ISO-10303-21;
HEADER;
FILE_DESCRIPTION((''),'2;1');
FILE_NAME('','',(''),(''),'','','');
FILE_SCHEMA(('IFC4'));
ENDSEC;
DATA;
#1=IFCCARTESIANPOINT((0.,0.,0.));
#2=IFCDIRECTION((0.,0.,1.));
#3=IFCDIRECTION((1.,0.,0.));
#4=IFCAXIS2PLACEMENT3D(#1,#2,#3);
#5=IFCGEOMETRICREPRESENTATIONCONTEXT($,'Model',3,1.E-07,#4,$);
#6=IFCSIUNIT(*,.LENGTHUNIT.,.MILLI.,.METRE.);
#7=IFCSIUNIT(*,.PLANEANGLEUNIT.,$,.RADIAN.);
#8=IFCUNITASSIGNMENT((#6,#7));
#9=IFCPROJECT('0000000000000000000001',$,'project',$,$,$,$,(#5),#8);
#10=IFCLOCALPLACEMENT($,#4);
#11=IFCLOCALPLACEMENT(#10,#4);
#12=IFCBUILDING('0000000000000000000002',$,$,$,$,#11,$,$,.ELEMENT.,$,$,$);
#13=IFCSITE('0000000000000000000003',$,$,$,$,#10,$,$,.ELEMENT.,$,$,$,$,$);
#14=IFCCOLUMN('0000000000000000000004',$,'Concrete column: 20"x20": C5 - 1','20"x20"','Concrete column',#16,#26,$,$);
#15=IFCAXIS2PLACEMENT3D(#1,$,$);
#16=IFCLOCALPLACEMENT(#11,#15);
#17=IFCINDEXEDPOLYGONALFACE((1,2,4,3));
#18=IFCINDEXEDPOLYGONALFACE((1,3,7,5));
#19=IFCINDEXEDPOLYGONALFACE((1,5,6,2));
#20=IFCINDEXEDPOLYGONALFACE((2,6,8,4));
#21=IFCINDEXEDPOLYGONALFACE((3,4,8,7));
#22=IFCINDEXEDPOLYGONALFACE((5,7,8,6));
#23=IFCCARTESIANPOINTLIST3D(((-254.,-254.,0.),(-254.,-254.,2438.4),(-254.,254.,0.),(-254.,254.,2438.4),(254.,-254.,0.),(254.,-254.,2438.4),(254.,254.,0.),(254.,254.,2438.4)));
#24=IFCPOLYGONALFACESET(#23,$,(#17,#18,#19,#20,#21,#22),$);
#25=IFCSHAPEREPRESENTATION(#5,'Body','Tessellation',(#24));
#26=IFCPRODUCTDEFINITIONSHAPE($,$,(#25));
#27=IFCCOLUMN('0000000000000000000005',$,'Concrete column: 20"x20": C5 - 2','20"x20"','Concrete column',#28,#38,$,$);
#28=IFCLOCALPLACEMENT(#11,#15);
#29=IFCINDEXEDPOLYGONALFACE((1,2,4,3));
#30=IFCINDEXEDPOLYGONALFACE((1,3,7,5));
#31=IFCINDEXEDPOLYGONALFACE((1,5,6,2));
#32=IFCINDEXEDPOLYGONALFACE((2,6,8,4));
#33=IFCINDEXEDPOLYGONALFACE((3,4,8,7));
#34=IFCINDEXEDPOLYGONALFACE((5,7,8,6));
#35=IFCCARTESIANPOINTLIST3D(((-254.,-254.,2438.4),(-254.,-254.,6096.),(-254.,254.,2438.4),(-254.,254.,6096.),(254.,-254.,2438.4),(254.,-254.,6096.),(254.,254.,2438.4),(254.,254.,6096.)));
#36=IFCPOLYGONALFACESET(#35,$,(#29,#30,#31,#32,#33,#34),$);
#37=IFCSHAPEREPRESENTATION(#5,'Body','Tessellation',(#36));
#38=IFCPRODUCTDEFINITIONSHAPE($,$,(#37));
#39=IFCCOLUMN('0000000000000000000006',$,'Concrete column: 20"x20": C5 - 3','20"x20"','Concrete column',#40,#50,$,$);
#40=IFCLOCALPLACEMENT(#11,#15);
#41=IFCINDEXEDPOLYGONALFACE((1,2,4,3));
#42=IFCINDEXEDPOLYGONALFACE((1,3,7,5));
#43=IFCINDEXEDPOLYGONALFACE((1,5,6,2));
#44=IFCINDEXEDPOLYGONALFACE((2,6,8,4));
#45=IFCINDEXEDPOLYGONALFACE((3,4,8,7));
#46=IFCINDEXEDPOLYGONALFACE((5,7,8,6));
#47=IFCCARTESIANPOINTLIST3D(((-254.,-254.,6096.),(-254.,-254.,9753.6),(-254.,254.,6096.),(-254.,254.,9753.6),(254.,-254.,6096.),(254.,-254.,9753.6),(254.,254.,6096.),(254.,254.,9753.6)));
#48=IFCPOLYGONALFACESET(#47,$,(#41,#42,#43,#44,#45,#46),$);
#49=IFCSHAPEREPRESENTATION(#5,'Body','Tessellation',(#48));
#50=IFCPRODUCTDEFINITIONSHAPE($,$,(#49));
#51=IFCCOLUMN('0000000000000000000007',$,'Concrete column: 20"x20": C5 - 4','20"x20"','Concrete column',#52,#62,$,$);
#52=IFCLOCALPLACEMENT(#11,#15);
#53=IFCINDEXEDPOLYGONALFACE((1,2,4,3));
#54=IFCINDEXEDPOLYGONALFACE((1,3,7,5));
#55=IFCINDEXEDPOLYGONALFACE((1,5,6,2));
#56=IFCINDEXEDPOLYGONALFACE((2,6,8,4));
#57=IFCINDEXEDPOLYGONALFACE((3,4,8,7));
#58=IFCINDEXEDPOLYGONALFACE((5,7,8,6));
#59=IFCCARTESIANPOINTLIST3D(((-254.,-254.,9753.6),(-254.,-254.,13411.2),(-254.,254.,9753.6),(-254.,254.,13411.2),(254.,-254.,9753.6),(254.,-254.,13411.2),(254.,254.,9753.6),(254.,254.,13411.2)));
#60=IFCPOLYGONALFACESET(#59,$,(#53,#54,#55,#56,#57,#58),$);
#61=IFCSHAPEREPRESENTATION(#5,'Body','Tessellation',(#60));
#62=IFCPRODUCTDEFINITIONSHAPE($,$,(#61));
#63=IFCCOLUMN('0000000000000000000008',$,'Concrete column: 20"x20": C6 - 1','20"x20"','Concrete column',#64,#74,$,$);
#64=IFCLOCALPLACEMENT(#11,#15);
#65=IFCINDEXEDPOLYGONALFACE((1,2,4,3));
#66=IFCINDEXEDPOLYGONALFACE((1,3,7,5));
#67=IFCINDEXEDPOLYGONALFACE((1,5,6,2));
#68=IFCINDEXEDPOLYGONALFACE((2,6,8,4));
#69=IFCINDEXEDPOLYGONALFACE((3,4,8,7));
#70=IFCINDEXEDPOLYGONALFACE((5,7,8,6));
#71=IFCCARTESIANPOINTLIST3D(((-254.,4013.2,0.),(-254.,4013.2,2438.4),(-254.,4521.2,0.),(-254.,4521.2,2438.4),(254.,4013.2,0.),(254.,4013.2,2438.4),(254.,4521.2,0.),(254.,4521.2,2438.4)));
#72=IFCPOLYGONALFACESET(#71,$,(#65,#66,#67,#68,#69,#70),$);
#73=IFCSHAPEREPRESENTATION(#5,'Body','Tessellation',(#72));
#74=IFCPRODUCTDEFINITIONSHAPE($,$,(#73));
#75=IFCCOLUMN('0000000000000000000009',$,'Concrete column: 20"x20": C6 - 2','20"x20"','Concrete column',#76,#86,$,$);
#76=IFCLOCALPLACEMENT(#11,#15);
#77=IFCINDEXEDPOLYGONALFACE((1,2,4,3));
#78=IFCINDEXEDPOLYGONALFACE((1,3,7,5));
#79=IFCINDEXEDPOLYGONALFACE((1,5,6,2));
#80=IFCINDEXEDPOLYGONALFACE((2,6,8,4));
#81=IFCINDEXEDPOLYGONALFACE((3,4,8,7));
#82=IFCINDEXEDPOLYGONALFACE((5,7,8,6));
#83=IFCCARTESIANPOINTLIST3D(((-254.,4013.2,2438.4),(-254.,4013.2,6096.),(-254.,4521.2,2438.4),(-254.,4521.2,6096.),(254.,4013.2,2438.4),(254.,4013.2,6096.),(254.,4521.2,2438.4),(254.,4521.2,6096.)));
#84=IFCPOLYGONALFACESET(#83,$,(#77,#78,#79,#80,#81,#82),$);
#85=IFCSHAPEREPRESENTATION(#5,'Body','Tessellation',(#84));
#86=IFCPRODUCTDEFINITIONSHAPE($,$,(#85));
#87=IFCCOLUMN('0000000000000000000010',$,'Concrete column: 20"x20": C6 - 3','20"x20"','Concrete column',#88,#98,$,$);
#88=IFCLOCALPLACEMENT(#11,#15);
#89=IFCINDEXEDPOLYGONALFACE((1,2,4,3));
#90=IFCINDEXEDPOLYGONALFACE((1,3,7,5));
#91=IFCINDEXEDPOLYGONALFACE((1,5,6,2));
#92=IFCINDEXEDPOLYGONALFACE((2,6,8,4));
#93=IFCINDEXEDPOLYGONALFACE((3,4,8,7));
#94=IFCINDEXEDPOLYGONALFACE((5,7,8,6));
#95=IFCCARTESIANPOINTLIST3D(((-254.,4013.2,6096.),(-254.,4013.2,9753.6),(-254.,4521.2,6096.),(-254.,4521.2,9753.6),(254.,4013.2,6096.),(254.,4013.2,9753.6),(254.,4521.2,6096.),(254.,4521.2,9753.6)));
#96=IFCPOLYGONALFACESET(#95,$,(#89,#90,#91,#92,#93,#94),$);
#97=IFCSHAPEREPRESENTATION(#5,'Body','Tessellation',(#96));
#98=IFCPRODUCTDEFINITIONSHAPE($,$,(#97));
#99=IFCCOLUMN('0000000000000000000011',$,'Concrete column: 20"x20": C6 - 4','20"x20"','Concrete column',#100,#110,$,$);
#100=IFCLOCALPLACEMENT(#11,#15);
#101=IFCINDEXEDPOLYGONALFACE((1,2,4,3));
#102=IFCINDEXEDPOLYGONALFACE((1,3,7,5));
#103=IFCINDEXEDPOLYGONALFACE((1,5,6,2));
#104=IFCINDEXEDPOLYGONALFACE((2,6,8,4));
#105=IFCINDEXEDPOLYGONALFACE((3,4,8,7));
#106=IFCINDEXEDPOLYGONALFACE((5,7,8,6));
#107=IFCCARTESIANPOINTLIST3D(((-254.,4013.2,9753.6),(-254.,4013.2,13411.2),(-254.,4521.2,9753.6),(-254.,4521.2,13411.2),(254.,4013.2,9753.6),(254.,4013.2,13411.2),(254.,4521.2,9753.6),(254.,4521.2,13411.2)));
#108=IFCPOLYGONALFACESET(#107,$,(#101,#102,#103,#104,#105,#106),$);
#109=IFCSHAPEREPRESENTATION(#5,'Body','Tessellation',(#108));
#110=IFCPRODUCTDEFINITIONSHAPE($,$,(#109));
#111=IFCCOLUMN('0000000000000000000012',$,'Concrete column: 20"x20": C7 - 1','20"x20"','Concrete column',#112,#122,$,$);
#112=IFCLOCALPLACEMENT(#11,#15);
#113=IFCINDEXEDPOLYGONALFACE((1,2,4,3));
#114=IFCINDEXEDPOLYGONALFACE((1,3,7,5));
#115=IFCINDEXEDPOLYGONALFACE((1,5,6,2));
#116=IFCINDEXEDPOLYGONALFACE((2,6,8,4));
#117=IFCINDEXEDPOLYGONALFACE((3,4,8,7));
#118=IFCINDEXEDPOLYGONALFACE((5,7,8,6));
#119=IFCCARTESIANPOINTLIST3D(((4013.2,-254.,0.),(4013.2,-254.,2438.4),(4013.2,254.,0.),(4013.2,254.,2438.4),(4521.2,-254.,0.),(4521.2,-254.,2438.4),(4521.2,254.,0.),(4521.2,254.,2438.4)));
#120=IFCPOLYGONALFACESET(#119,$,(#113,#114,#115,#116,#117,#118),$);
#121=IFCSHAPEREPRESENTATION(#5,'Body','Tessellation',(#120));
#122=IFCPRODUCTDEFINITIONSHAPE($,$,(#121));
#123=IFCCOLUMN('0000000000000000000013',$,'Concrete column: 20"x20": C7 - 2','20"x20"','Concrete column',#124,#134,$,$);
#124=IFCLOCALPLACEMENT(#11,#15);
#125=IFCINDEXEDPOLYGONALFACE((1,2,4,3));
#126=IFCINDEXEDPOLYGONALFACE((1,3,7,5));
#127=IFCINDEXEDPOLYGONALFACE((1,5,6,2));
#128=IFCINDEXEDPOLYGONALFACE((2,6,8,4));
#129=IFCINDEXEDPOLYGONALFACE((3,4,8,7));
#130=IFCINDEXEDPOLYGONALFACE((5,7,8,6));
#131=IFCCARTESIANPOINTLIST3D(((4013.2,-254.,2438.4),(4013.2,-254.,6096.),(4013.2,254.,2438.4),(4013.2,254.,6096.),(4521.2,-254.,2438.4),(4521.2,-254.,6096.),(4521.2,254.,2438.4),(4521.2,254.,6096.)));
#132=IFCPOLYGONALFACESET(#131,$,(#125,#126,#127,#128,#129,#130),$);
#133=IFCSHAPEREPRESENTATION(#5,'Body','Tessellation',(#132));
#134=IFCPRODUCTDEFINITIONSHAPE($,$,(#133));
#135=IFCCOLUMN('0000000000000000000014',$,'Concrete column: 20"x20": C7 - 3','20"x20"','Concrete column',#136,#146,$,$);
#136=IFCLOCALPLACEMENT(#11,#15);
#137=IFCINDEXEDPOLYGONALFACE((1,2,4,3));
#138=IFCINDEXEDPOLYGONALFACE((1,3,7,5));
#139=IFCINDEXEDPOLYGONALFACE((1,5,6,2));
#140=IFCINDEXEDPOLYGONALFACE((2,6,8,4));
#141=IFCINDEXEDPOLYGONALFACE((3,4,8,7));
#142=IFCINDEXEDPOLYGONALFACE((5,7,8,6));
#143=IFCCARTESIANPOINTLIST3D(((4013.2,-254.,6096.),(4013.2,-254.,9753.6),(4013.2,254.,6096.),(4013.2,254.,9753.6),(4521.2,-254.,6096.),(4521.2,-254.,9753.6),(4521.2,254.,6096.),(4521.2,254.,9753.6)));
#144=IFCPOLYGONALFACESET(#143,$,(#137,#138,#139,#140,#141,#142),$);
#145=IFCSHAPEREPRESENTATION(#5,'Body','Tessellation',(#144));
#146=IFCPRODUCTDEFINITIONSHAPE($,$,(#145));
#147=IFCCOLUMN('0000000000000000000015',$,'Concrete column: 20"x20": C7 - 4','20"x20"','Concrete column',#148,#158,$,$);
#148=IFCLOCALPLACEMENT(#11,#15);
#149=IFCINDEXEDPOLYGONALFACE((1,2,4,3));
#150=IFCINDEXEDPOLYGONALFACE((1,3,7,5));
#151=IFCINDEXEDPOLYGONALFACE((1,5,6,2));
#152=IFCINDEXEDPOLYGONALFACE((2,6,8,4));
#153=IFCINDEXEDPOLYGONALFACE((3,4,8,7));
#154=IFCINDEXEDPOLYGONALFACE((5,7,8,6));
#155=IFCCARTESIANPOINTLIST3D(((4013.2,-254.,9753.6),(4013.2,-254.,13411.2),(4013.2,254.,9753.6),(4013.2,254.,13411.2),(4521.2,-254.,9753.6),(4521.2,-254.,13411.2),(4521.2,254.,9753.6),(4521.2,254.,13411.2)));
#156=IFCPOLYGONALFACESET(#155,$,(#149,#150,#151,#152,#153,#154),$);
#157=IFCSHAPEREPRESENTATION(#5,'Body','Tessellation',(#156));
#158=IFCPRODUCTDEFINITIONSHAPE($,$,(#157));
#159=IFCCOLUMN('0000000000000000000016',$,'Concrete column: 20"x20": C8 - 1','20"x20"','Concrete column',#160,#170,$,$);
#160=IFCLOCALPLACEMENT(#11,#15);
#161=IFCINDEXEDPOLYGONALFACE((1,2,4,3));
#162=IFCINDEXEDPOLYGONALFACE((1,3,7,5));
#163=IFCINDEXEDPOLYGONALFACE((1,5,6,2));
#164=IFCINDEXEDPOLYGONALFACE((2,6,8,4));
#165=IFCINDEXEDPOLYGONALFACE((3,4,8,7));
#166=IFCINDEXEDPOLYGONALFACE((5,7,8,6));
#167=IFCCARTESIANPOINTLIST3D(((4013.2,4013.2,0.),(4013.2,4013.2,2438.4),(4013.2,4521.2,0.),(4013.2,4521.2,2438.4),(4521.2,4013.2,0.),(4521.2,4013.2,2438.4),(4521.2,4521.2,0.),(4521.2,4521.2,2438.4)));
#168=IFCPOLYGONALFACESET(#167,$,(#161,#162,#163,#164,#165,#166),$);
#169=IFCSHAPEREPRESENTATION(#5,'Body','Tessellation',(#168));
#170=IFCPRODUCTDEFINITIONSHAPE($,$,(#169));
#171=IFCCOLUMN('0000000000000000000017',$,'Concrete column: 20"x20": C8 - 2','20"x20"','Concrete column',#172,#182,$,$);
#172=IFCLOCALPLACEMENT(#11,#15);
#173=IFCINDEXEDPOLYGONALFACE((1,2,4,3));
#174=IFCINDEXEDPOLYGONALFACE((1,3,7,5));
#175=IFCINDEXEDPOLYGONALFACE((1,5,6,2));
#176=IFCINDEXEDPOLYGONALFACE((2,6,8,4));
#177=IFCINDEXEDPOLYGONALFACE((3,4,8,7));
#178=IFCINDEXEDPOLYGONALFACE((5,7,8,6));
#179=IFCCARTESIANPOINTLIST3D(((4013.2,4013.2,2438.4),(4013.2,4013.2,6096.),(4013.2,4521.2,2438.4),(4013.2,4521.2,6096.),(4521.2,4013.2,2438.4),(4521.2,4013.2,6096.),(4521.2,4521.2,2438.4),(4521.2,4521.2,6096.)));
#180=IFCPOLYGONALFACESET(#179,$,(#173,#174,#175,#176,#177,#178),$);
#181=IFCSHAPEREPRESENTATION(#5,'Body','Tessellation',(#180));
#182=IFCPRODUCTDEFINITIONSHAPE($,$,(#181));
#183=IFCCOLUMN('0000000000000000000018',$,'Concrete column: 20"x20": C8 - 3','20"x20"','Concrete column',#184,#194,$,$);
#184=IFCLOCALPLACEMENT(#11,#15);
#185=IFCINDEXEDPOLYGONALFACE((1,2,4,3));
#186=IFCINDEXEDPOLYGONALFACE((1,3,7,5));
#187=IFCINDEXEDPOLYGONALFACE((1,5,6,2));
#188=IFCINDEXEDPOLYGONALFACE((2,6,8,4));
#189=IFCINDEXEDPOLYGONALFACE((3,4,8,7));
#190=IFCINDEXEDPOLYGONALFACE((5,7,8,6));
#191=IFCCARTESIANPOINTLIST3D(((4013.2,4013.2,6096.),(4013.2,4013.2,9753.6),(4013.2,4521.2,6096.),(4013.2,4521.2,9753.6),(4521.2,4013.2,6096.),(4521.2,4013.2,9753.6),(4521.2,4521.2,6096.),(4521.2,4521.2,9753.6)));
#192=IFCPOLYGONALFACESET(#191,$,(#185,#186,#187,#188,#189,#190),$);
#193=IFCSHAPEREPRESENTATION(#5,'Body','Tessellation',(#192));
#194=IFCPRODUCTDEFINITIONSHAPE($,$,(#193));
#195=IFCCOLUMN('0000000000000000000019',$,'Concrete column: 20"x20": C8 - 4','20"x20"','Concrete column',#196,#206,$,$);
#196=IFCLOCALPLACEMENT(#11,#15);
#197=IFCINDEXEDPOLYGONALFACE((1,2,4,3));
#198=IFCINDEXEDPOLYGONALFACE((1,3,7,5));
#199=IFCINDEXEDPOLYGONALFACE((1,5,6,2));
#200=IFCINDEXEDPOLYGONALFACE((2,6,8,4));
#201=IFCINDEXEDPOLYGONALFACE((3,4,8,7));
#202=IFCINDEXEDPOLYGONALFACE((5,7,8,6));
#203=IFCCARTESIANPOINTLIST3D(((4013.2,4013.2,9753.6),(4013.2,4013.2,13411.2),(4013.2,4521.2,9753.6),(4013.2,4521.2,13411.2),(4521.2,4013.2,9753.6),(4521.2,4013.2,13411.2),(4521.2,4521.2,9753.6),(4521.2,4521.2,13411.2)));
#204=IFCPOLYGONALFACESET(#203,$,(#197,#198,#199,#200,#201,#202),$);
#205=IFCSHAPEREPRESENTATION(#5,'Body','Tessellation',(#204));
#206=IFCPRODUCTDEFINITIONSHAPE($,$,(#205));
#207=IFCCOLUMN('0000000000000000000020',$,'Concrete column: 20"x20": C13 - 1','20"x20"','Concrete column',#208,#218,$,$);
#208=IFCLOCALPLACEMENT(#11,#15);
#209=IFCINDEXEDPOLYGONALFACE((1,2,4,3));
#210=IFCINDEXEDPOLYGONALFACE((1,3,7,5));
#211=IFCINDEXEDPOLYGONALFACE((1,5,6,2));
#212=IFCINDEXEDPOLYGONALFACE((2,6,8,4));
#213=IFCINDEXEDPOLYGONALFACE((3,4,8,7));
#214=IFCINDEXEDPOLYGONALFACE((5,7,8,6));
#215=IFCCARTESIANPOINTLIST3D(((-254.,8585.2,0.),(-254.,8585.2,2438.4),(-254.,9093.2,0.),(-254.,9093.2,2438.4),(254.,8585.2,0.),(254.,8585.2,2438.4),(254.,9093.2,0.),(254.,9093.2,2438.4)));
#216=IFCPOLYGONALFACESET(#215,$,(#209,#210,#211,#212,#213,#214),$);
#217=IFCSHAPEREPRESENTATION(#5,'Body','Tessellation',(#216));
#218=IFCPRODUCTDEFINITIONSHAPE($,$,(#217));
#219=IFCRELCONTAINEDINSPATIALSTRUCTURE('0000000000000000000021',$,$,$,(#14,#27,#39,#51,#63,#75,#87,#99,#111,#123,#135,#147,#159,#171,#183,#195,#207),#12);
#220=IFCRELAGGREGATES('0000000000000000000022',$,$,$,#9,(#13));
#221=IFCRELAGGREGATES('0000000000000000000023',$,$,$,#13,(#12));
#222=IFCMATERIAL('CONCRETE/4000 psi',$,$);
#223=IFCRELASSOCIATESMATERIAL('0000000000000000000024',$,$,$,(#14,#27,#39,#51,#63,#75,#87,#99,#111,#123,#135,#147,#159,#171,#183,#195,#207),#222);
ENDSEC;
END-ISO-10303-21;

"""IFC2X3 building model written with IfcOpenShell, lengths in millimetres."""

from ifc_helpers import new_model, si_unit, frame, origin_with_axes, origin_2d_with_axis, place, context, project, spatial, rectangle, extrude, material, element, save


model = new_model("IFC2X3")

# Units and contexts
model_context = context("Model", 3, precision=1e-07, world=origin_with_axes())
ifc_project = project(units=[si_unit("LENGTHUNIT", "METRE", prefix="MILLI"), si_unit("PLANEANGLEUNIT", "RADIAN")], contexts=[model_context])

# Site, building
site_placement = place(None, origin_with_axes())
site = spatial("IfcSite", under=ifc_project, at=site_placement, CompositionType="ELEMENT")
building_placement = place(site_placement, origin_with_axes())
building = spatial("IfcBuilding", under=site, at=building_placement, CompositionType="ELEMENT")

# Columns
ifc_material = material(Name="CONCRETE/4000 psi")
column_1_placement = place(building_placement, frame((0.0, 0.0, 0.0), z_axis=(0.0, 0.0, 1.0), x_axis=(1.0, 0.0, 0.0)))
element("IfcColumn", 1, at=column_1_placement, inside=building, material=ifc_material, Name="Concrete column: 20\"x20\": C5 - 1", Description="20\"x20\"", ObjectType="Concrete column", context=model_context, shape_type="SweptSolid", body=[
    extrude(rectangle(XDim=508.0, YDim=508.0, at=origin_2d_with_axis()), origin_with_axes(), (0.0, 0.0, 1.0), 2438.4),
])
for number, where, z_axis, x_axis, name in (
    (2, (0.0, 0.0, 2438.4), (0.0, 0.0, 1.0), (1.0, 0.0, 0.0), "Concrete column: 20\"x20\": C5 - 2"),
    (3, (0.0, 0.0, 6096.0), (0.0, 0.0, 1.0), (1.0, 0.0, 0.0), "Concrete column: 20\"x20\": C5 - 3"),
    (4, (0.0, 0.0, 9753.6), (0.0, 0.0, 1.0), (1.0, 0.0, 0.0), "Concrete column: 20\"x20\": C5 - 4"),
):
    element("IfcColumn", number, at=place(building_placement, frame(where, z_axis=z_axis, x_axis=x_axis)), inside=building, material=ifc_material, Name=name, Description="20\"x20\"", ObjectType="Concrete column", context=model_context, shape_type="SweptSolid", body=[
        extrude(rectangle(XDim=508.0, YDim=508.0, at=origin_2d_with_axis()), origin_with_axes(), (0.0, 0.0, 1.0), 3657.6),
    ])
column_2_placement = place(building_placement, frame((0.0, 4267.2, 0.0), z_axis=(0.0, 0.0, 1.0), x_axis=(1.0, 0.0, 0.0)))
element("IfcColumn", 5, at=column_2_placement, inside=building, material=ifc_material, Name="Concrete column: 20\"x20\": C6 - 1", Description="20\"x20\"", ObjectType="Concrete column", context=model_context, shape_type="SweptSolid", body=[
    extrude(rectangle(XDim=508.0, YDim=508.0, at=origin_2d_with_axis()), origin_with_axes(), (0.0, 0.0, 1.0), 2438.4),
])
for number, where, z_axis, x_axis, name in (
    (6, (0.0, 4267.2, 2438.4), (0.0, 0.0, 1.0), (1.0, 0.0, 0.0), "Concrete column: 20\"x20\": C6 - 2"),
    (7, (0.0, 4267.2, 6096.0), (0.0, 0.0, 1.0), (1.0, 0.0, 0.0), "Concrete column: 20\"x20\": C6 - 3"),
    (8, (0.0, 4267.2, 9753.6), (0.0, 0.0, 1.0), (1.0, 0.0, 0.0), "Concrete column: 20\"x20\": C6 - 4"),
):
    element("IfcColumn", number, at=place(building_placement, frame(where, z_axis=z_axis, x_axis=x_axis)), inside=building, material=ifc_material, Name=name, Description="20\"x20\"", ObjectType="Concrete column", context=model_context, shape_type="SweptSolid", body=[
        extrude(rectangle(XDim=508.0, YDim=508.0, at=origin_2d_with_axis()), origin_with_axes(), (0.0, 0.0, 1.0), 3657.6),
    ])
column_3_placement = place(building_placement, frame((4267.2, 0.0, 0.0), z_axis=(0.0, 0.0, 1.0), x_axis=(1.0, 0.0, 0.0)))
element("IfcColumn", 9, at=column_3_placement, inside=building, material=ifc_material, Name="Concrete column: 20\"x20\": C7 - 1", Description="20\"x20\"", ObjectType="Concrete column", context=model_context, shape_type="SweptSolid", body=[
    extrude(rectangle(XDim=508.0, YDim=508.0, at=origin_2d_with_axis()), origin_with_axes(), (0.0, 0.0, 1.0), 2438.4),
])
for number, where, z_axis, x_axis, name in (
    (10, (4267.2, 0.0, 2438.4), (0.0, 0.0, 1.0), (1.0, 0.0, 0.0), "Concrete column: 20\"x20\": C7 - 2"),
    (11, (4267.2, 0.0, 6096.0), (0.0, 0.0, 1.0), (1.0, 0.0, 0.0), "Concrete column: 20\"x20\": C7 - 3"),
    (12, (4267.2, 0.0, 9753.6), (0.0, 0.0, 1.0), (1.0, 0.0, 0.0), "Concrete column: 20\"x20\": C7 - 4"),
):
    element("IfcColumn", number, at=place(building_placement, frame(where, z_axis=z_axis, x_axis=x_axis)), inside=building, material=ifc_material, Name=name, Description="20\"x20\"", ObjectType="Concrete column", context=model_context, shape_type="SweptSolid", body=[
        extrude(rectangle(XDim=508.0, YDim=508.0, at=origin_2d_with_axis()), origin_with_axes(), (0.0, 0.0, 1.0), 3657.6),
    ])
column_4_placement = place(building_placement, frame((4267.2, 4267.2, 0.0), z_axis=(0.0, 0.0, 1.0), x_axis=(1.0, 0.0, 0.0)))
element("IfcColumn", 13, at=column_4_placement, inside=building, material=ifc_material, Name="Concrete column: 20\"x20\": C8 - 1", Description="20\"x20\"", ObjectType="Concrete column", context=model_context, shape_type="SweptSolid", body=[
    extrude(rectangle(XDim=508.0, YDim=508.0, at=origin_2d_with_axis()), origin_with_axes(), (0.0, 0.0, 1.0), 2438.4),
])
for number, where, z_axis, x_axis, name in (
    (14, (4267.2, 4267.2, 2438.4), (0.0, 0.0, 1.0), (1.0, 0.0, 0.0), "Concrete column: 20\"x20\": C8 - 2"),
    (15, (4267.2, 4267.2, 6096.0), (0.0, 0.0, 1.0), (1.0, 0.0, 0.0), "Concrete column: 20\"x20\": C8 - 3"),
    (16, (4267.2, 4267.2, 9753.6), (0.0, 0.0, 1.0), (1.0, 0.0, 0.0), "Concrete column: 20\"x20\": C8 - 4"),
):
    element("IfcColumn", number, at=place(building_placement, frame(where, z_axis=z_axis, x_axis=x_axis)), inside=building, material=ifc_material, Name=name, Description="20\"x20\"", ObjectType="Concrete column", context=model_context, shape_type="SweptSolid", body=[
        extrude(rectangle(XDim=508.0, YDim=508.0, at=origin_2d_with_axis()), origin_with_axes(), (0.0, 0.0, 1.0), 3657.6),
    ])
column_5_placement = place(building_placement, frame((0.0, 8839.2, 0.0), z_axis=(0.0, 0.0, 1.0), x_axis=(1.0, 0.0, 0.0)))
element("IfcColumn", 17, at=column_5_placement, inside=building, material=ifc_material, Name="Concrete column: 20\"x20\": C13 - 1", Description="20\"x20\"", ObjectType="Concrete column", context=model_context, shape_type="SweptSolid", body=[
    extrude(rectangle(XDim=508.0, YDim=508.0, at=origin_2d_with_axis()), origin_with_axes(), (0.0, 0.0, 1.0), 2438.4),
])

save(model, "model.ifc")
